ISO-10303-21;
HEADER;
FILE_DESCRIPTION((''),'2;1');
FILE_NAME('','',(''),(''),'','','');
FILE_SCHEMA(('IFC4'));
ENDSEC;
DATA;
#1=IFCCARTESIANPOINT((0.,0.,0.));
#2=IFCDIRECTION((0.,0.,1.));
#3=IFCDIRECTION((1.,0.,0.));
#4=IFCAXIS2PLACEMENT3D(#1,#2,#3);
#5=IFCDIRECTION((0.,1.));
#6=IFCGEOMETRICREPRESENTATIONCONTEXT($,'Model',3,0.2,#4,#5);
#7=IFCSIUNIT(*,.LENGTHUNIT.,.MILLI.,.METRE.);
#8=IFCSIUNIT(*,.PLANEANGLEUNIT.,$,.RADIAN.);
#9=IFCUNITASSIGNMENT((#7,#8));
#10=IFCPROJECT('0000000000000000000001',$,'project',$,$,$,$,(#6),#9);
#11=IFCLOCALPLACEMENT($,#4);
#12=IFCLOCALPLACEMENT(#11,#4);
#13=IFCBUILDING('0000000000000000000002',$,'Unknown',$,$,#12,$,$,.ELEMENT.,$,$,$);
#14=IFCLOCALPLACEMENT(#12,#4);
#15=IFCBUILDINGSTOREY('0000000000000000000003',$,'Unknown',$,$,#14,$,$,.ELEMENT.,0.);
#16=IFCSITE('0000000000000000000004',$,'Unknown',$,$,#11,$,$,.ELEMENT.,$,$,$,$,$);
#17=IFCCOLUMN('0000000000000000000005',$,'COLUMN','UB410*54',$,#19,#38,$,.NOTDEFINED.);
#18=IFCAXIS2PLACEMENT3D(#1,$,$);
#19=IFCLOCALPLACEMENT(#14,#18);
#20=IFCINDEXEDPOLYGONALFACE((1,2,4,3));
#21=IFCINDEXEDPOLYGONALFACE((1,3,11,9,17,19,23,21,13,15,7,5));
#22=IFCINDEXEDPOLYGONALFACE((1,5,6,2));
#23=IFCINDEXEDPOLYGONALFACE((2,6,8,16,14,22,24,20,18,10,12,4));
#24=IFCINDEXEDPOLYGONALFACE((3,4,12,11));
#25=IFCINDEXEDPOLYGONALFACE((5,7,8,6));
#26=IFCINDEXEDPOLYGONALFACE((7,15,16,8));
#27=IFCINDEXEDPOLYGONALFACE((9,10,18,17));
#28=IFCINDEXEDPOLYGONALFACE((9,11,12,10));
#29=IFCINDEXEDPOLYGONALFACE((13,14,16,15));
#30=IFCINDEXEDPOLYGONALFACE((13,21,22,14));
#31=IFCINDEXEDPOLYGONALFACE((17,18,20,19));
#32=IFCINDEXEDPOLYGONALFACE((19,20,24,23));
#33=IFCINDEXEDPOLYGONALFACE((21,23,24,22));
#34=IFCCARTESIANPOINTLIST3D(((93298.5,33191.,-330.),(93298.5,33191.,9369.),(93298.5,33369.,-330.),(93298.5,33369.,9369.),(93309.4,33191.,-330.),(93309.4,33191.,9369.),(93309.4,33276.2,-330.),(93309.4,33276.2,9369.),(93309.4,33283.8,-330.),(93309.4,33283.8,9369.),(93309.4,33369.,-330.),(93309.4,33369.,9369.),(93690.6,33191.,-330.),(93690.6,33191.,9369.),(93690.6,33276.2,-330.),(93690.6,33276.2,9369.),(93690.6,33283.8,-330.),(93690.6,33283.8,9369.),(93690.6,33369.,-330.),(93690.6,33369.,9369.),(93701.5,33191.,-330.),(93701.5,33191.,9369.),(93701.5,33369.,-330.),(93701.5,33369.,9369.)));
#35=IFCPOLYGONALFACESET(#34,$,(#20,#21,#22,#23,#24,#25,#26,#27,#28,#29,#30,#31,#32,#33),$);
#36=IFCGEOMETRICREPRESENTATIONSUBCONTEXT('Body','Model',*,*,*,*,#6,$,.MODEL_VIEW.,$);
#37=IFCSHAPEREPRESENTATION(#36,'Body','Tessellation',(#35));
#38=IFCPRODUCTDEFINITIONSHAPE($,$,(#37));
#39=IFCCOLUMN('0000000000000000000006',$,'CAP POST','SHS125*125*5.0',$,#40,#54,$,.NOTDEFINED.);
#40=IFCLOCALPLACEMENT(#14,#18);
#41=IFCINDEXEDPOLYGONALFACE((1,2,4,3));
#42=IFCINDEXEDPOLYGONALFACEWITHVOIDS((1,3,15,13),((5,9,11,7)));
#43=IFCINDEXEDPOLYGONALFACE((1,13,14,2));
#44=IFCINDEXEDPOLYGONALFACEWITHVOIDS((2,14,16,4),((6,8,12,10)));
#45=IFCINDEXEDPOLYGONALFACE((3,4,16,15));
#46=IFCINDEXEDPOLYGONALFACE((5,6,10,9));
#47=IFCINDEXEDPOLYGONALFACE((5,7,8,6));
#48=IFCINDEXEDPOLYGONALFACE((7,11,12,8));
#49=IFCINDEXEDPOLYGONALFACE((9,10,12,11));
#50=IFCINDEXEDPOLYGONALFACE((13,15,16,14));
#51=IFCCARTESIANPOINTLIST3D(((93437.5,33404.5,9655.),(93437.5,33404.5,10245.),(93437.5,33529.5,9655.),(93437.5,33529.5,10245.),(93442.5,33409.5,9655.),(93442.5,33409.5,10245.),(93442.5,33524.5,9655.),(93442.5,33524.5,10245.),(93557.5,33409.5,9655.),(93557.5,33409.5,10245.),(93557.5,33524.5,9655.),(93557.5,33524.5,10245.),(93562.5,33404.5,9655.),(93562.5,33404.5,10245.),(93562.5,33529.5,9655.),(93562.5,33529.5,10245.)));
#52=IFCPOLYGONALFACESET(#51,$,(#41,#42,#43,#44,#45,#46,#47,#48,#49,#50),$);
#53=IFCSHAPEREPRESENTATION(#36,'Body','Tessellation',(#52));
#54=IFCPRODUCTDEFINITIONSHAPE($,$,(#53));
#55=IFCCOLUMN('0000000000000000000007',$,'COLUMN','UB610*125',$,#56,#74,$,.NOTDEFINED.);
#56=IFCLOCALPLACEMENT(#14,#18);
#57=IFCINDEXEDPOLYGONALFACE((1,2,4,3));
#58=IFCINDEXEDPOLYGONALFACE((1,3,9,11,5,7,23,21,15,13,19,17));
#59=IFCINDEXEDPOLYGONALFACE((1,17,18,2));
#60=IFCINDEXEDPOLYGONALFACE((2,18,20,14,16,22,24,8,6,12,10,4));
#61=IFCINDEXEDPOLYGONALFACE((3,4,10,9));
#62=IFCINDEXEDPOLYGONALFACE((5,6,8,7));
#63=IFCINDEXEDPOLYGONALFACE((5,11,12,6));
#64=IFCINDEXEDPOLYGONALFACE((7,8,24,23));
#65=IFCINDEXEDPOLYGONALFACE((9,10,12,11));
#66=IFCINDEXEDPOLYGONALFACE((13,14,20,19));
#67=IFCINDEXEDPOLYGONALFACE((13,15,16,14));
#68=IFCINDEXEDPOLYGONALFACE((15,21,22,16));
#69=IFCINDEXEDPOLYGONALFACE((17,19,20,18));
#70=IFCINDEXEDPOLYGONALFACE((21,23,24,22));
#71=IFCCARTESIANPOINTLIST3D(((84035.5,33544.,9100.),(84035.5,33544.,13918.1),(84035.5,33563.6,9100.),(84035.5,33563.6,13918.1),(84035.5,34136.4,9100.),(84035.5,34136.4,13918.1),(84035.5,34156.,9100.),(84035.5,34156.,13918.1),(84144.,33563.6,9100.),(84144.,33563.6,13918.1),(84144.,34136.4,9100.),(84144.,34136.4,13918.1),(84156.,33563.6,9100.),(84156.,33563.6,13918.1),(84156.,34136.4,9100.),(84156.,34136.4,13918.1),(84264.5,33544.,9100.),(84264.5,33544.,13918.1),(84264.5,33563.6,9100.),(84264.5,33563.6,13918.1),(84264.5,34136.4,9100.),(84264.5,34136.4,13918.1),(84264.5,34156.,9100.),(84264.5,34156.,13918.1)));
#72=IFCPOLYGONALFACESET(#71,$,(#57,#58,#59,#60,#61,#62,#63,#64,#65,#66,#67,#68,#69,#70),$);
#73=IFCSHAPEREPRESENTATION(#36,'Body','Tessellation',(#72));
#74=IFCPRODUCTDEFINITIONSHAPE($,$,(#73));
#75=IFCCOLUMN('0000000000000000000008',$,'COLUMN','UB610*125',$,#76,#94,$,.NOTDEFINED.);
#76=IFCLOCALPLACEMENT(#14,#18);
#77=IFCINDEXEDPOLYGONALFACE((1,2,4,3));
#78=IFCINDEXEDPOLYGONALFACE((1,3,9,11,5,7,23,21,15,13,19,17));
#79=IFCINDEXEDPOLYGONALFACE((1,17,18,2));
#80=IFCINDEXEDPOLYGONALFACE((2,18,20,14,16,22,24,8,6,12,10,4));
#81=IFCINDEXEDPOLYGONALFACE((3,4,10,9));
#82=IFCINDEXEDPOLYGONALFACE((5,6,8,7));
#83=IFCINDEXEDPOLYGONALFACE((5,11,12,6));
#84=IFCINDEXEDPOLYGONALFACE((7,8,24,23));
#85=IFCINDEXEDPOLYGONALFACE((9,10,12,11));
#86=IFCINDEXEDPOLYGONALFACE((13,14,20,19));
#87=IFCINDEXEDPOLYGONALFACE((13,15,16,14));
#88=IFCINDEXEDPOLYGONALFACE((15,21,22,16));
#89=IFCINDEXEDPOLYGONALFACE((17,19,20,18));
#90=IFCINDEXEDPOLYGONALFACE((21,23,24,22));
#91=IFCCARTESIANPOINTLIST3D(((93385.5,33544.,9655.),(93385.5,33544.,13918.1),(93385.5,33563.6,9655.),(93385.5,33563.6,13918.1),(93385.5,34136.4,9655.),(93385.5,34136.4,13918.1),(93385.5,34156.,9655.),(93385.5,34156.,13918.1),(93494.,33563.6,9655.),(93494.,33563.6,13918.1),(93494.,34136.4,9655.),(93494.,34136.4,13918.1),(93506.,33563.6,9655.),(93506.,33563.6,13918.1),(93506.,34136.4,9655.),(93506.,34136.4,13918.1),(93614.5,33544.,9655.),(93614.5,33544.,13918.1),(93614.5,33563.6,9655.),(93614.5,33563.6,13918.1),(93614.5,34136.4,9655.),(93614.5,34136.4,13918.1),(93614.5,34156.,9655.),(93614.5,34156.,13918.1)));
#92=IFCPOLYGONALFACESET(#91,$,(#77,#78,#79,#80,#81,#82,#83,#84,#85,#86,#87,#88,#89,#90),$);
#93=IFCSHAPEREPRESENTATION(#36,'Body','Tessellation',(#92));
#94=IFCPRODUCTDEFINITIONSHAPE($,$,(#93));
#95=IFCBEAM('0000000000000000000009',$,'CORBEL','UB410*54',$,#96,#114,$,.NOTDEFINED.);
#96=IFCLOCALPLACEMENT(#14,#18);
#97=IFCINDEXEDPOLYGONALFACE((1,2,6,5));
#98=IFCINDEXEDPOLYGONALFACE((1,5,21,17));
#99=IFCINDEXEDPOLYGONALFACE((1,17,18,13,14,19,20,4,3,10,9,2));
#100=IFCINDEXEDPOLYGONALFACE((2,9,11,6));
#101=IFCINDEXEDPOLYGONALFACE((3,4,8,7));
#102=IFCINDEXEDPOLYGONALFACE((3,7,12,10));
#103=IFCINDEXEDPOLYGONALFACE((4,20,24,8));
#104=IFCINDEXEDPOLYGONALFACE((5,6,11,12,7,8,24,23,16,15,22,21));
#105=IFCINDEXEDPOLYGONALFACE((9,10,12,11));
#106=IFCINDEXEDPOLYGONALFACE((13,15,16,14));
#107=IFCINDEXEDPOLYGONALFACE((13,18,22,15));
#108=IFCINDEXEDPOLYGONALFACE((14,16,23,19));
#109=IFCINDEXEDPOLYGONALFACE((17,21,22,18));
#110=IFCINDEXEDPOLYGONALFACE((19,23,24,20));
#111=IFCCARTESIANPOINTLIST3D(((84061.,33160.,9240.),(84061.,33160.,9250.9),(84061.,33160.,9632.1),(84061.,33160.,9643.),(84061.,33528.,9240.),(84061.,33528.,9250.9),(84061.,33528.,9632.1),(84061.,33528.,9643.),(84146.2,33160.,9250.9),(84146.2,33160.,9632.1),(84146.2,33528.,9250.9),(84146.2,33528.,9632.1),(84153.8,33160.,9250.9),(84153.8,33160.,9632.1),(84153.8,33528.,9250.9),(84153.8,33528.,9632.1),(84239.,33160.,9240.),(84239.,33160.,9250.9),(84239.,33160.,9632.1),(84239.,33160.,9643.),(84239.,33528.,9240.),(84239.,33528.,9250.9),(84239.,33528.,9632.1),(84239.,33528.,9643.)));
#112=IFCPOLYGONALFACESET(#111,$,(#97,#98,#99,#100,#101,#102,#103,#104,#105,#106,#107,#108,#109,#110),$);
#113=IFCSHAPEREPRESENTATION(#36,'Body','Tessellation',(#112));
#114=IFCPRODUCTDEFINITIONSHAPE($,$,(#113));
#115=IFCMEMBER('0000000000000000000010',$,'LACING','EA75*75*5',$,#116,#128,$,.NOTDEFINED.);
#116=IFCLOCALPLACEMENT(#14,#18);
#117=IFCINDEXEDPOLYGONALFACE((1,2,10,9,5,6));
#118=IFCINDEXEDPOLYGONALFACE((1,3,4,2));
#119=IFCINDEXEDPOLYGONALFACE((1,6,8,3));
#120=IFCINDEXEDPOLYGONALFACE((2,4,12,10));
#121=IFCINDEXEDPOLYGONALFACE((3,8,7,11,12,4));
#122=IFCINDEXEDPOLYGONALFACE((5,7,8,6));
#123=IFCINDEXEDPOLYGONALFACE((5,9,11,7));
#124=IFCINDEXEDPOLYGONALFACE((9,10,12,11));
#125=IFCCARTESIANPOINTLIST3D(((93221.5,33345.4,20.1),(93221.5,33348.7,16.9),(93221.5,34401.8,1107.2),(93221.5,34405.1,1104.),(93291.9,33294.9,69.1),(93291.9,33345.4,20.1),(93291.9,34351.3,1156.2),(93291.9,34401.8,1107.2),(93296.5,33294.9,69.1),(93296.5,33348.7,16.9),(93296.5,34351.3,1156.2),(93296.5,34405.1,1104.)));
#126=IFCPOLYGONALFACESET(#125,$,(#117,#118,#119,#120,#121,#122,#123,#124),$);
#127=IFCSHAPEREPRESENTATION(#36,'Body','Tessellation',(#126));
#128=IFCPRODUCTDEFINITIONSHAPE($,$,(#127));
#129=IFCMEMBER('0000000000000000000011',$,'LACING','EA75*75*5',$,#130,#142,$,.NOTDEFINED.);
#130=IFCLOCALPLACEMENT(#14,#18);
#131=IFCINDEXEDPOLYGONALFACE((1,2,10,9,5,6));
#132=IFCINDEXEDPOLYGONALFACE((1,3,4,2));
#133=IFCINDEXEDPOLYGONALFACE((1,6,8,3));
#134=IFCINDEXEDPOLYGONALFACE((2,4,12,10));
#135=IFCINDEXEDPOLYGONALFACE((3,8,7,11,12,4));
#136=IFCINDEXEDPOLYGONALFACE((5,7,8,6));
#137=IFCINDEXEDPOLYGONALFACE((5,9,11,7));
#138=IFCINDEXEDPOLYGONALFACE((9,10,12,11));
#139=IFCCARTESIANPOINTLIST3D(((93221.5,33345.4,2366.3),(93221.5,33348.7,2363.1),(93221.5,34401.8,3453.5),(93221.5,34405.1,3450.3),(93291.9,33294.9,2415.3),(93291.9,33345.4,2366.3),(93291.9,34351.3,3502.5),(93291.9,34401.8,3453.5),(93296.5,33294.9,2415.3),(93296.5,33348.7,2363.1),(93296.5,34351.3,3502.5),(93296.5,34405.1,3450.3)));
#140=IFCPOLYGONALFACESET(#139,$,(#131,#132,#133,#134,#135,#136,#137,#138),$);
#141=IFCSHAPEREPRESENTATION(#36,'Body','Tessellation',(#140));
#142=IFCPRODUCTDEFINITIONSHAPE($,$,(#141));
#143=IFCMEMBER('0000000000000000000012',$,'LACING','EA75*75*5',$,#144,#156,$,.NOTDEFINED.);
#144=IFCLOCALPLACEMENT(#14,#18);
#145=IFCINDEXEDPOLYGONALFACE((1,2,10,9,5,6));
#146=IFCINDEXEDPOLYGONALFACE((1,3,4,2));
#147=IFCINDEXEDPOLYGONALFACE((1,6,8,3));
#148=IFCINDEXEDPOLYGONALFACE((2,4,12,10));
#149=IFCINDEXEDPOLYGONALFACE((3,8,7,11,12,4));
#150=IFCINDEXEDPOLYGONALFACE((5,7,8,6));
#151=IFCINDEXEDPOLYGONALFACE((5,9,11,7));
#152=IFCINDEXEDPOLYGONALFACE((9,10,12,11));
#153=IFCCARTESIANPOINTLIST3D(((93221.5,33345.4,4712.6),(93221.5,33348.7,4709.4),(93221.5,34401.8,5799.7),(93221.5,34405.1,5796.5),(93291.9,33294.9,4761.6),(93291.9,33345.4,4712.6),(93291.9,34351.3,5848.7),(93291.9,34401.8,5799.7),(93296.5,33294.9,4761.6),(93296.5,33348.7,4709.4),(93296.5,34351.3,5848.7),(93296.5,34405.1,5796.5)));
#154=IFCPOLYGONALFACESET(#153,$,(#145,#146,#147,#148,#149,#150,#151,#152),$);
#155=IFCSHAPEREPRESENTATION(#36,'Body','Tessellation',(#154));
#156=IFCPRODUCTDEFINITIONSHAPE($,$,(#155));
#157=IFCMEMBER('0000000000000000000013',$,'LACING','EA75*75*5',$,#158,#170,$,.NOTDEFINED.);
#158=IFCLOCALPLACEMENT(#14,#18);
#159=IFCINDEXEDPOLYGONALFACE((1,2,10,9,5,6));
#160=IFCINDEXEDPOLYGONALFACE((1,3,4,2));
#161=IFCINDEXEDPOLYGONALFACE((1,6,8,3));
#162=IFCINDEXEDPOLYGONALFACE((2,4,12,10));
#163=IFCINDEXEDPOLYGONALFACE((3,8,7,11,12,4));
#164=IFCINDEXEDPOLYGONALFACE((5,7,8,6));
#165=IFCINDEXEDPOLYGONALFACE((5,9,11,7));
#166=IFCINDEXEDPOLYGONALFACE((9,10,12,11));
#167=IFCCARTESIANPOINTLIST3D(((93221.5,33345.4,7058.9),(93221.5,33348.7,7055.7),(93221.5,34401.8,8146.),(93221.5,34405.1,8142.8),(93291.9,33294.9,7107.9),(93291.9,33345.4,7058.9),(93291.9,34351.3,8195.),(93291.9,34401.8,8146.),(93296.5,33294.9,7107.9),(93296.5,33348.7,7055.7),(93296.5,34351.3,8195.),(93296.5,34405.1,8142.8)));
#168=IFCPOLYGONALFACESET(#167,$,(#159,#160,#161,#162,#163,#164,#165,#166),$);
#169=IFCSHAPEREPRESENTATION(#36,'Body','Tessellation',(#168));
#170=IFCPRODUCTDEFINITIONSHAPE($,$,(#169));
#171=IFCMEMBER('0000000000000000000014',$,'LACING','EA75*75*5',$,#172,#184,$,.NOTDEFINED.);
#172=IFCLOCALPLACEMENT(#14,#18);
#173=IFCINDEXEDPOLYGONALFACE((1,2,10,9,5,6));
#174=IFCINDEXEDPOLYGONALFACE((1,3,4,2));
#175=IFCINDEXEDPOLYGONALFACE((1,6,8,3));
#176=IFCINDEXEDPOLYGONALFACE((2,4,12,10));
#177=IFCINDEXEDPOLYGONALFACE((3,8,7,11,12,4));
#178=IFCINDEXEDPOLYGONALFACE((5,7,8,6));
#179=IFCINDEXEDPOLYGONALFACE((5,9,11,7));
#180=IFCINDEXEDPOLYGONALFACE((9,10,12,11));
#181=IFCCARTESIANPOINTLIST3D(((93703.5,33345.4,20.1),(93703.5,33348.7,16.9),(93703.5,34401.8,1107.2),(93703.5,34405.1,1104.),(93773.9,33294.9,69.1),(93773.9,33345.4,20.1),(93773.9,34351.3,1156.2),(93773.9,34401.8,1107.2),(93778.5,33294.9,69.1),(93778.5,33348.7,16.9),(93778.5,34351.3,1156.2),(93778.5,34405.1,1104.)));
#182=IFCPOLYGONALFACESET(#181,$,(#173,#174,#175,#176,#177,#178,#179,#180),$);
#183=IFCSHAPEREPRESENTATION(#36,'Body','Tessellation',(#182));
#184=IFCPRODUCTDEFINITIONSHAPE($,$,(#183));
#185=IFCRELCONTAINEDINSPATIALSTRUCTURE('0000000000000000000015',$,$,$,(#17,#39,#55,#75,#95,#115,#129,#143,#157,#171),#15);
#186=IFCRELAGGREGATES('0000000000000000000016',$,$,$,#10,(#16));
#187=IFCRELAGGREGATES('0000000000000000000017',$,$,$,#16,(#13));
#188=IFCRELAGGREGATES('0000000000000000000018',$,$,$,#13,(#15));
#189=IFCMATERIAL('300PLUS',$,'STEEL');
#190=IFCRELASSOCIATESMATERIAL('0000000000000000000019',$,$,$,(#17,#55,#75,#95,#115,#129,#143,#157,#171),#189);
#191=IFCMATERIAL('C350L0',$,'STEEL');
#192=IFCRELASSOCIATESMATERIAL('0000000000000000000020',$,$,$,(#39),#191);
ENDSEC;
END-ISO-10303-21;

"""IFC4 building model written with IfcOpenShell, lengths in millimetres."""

from ifc_helpers import new_model, si_unit, direction, frame, origin_with_axes, place, context, subcontext, project, spatial, line, indexed_curve, outline, extrude, material, element, save


model = new_model("IFC4")

# Units and contexts
model_context = context("Model", 3, precision=0.2, world=origin_with_axes(), true_north=direction((0.0, 1.0)))
body_context = subcontext(model_context, "Body", "Model", "MODEL_VIEW")
ifc_project = project(units=[si_unit("LENGTHUNIT", "METRE", prefix="MILLI"), si_unit("PLANEANGLEUNIT", "RADIAN")], contexts=[model_context])

# Site, building, storey
site_placement = place(None, origin_with_axes())
site = spatial("IfcSite", under=ifc_project, at=site_placement, Name="Unknown", CompositionType="ELEMENT")
building_placement = place(site_placement, origin_with_axes())
building = spatial("IfcBuilding", under=site, at=building_placement, Name="Unknown", CompositionType="ELEMENT")
storey_placement = place(building_placement, origin_with_axes())
storey = spatial("IfcBuildingStorey", under=building, at=storey_placement, Name="Unknown", CompositionType="ELEMENT", Elevation=0.0)

# Columns
ifc_material_1 = material(Name="300PLUS", Category="STEEL")
column_1_placement = place(storey_placement, frame((93500.0, 33280.0, -330.0), z_axis=(0.0, -1.0, 0.0), x_axis=(0.0, 0.0, 1.0)))
element("IfcColumn", 1, at=column_1_placement, inside=storey, material=ifc_material_1, Name="COLUMN", Description="UB410*54", PredefinedType="NOTDEFINED", context=body_context, shape_type="SolidModel", body=[
    extrude(outline(indexed_curve([(-89.0, -201.5), (89.0, -201.5), (89.0, -190.6), (3.8, -190.6), (3.8, 190.6), (89.0, 190.6), (89.0, 201.5), (-89.0, 201.5), (-89.0, 190.6), (-3.8, 190.6), (-3.8, -190.6), (-89.0, -190.6)], segments=[line(1, 2, 3, 4, 5, 6, 7, 8, 9, 10, 11, 12, 1)])), frame((0.0, 0.0, 0.0), z_axis=(-1.0, 0.0, 0.0), x_axis=(0.0, 0.0, 1.0)), (0.0, 0.0, -1.0), 9699.0),
])
ifc_material_2 = material(Name="C350L0", Category="STEEL")
column_2_placement = place(storey_placement, frame((93500.0, 33467.0, 9655.0), z_axis=(-1.0, 0.0, 0.0), x_axis=(0.0, 0.0, 1.0)))
element("IfcColumn", 2, at=column_2_placement, inside=storey, material=ifc_material_2, Name="CAP POST", Description="SHS125*125*5.0", PredefinedType="NOTDEFINED", context=body_context, shape_type="SolidModel", body=[
    extrude(outline(indexed_curve([(-62.5, -62.5), (62.5, -62.5), (62.5, 62.5), (-62.5, 62.5)], segments=[line(1, 2, 3, 4, 1)]), holes=[indexed_curve([(-57.5, -57.5), (-57.5, 57.5), (57.5, 57.5), (57.5, -57.5)], segments=[line(1, 2, 3, 4, 1)])]), frame((0.0, 0.0, 0.0), z_axis=(-1.0, 0.0, 0.0), x_axis=(0.0, 0.0, 1.0)), (0.0, 0.0, -1.0), 590.0),
])
column_3_placement = place(storey_placement, frame((84150.0, 33850.0, 9100.0), z_axis=(-1.0, 0.0, 0.0), x_axis=(0.0, 0.0, 1.0)))
element("IfcColumn", 3, at=column_3_placement, inside=storey, material=ifc_material_1, Name="COLUMN", Description="UB610*125", PredefinedType="NOTDEFINED", context=body_context, shape_type="SolidModel", body=[
    extrude(outline(indexed_curve([(-114.5, -306.0), (114.5, -306.0), (114.5, -286.4), (6.0, -286.4), (6.0, 286.4), (114.5, 286.4), (114.5, 306.0), (-114.5, 306.0), (-114.5, 286.4), (-6.0, 286.4), (-6.0, -286.4), (-114.5, -286.4)], segments=[line(1, 2, 3, 4, 5, 6, 7, 8, 9, 10, 11, 12, 1)])), frame((0.0, 0.0, 0.0), z_axis=(-1.0, 0.0, 0.0), x_axis=(0.0, 0.0, 1.0)), (0.0, 0.0, -1.0), 4818.1),
])
column_4_placement = place(storey_placement, frame((93500.0, 33850.0, 9655.0), z_axis=(-1.0, 0.0, 0.0), x_axis=(0.0, 0.0, 1.0)))
element("IfcColumn", 4, at=column_4_placement, inside=storey, material=ifc_material_1, Name="COLUMN", Description="UB610*125", PredefinedType="NOTDEFINED", context=body_context, shape_type="SolidModel", body=[
    extrude(outline(indexed_curve([(-114.5, -306.0), (114.5, -306.0), (114.5, -286.4), (6.0, -286.4), (6.0, 286.4), (114.5, 286.4), (114.5, 306.0), (-114.5, 306.0), (-114.5, 286.4), (-6.0, 286.4), (-6.0, -286.4), (-114.5, -286.4)], segments=[line(1, 2, 3, 4, 5, 6, 7, 8, 9, 10, 11, 12, 1)])), frame((0.0, 0.0, 0.0), z_axis=(-1.0, 0.0, 0.0), x_axis=(0.0, 0.0, 1.0)), (0.0, 0.0, -1.0), 4263.1),
])

# Beam
beam_1_placement = place(storey_placement, frame((84150.0, 33528.0, 9441.5), z_axis=(-1.0, 0.0, 0.0), x_axis=(0.0, -1.0, 0.0)))
element("IfcBeam", 5, at=beam_1_placement, inside=storey, material=ifc_material_1, Name="CORBEL", Description="UB410*54", PredefinedType="NOTDEFINED", context=body_context, shape_type="SolidModel", body=[
    extrude(outline(indexed_curve([(-89.0, -201.5), (89.0, -201.5), (89.0, -190.6), (3.8, -190.6), (3.8, 190.6), (89.0, 190.6), (89.0, 201.5), (-89.0, 201.5), (-89.0, 190.6), (-3.8, 190.6), (-3.8, -190.6), (-89.0, -190.6)], segments=[line(1, 2, 3, 4, 5, 6, 7, 8, 9, 10, 11, 12, 1)])), frame((0.0, 0.0, 0.0), z_axis=(-1.0, 0.0, 0.0), x_axis=(0.0, 0.0, 1.0)), (0.0, 0.0, -1.0), 368.0),
])

# Members
member_1_placement = place(storey_placement, frame((93259.0, 33321.8, 43.0), z_axis=(0.0, -0.717161, 0.696908), x_axis=(0.0, 0.696908, 0.717161)))
element("IfcMember", 6, at=member_1_placement, inside=storey, material=ifc_material_1, Name="LACING", Description="EA75*75*5", PredefinedType="NOTDEFINED", context=body_context, shape_type="SolidModel", body=[
    extrude(outline(indexed_curve([(-37.5, -37.5), (37.5, -37.5), (37.5, -32.9), (-32.9, -32.9), (-32.9, 37.5), (-37.5, 37.5)], segments=[line(1, 2, 3, 4, 5, 6, 1)])), frame((0.0, 0.0, 0.0), z_axis=(-1.0, 0.0, 0.0), x_axis=(0.0, 0.0, 1.0)), (0.0, 0.0, -1.0), 1515.8),
])
member_2_placement = place(storey_placement, frame((93259.0, 33321.8, 2389.2), z_axis=(0.0, -0.717193, 0.696875), x_axis=(0.0, 0.696875, 0.717193)))
element("IfcMember", 7, at=member_2_placement, inside=storey, material=ifc_material_1, Name="LACING", Description="EA75*75*5", PredefinedType="NOTDEFINED", context=body_context, shape_type="SolidModel", body=[
    extrude(outline(indexed_curve([(-37.5, -37.5), (37.5, -37.5), (37.5, -32.9), (-32.9, -32.9), (-32.9, 37.5), (-37.5, 37.5)], segments=[line(1, 2, 3, 4, 5, 6, 1)])), frame((0.0, 0.0, 0.0), z_axis=(-1.0, 0.0, 0.0), x_axis=(0.0, 0.0, 1.0)), (0.0, 0.0, -1.0), 1515.9),
])
for number, where, z_axis, x_axis, name in (
    (8, (93259.0, 33321.8, 4735.5), (0.0, -0.717161, 0.696908), (0.0, 0.696908, 0.717161), "LACING"),
    (9, (93259.0, 33321.8, 7081.8), (0.0, -0.717161, 0.696908), (0.0, 0.696908, 0.717161), "LACING"),
    (10, (93741.0, 33321.8, 43.0), (0.0, -0.717161, 0.696908), (0.0, 0.696908, 0.717161), "LACING"),
):
    element("IfcMember", number, at=place(storey_placement, frame(where, z_axis=z_axis, x_axis=x_axis)), inside=storey, material=ifc_material_1, Name=name, Description="EA75*75*5", PredefinedType="NOTDEFINED", context=body_context, shape_type="SolidModel", body=[
        extrude(outline(indexed_curve([(-37.5, -37.5), (37.5, -37.5), (37.5, -32.9), (-32.9, -32.9), (-32.9, 37.5), (-37.5, 37.5)], segments=[line(1, 2, 3, 4, 5, 6, 1)])), frame((0.0, 0.0, 0.0), z_axis=(-1.0, 0.0, 0.0), x_axis=(0.0, 0.0, 1.0)), (0.0, 0.0, -1.0), 1515.8),
    ])

save(model, "model.ifc")
